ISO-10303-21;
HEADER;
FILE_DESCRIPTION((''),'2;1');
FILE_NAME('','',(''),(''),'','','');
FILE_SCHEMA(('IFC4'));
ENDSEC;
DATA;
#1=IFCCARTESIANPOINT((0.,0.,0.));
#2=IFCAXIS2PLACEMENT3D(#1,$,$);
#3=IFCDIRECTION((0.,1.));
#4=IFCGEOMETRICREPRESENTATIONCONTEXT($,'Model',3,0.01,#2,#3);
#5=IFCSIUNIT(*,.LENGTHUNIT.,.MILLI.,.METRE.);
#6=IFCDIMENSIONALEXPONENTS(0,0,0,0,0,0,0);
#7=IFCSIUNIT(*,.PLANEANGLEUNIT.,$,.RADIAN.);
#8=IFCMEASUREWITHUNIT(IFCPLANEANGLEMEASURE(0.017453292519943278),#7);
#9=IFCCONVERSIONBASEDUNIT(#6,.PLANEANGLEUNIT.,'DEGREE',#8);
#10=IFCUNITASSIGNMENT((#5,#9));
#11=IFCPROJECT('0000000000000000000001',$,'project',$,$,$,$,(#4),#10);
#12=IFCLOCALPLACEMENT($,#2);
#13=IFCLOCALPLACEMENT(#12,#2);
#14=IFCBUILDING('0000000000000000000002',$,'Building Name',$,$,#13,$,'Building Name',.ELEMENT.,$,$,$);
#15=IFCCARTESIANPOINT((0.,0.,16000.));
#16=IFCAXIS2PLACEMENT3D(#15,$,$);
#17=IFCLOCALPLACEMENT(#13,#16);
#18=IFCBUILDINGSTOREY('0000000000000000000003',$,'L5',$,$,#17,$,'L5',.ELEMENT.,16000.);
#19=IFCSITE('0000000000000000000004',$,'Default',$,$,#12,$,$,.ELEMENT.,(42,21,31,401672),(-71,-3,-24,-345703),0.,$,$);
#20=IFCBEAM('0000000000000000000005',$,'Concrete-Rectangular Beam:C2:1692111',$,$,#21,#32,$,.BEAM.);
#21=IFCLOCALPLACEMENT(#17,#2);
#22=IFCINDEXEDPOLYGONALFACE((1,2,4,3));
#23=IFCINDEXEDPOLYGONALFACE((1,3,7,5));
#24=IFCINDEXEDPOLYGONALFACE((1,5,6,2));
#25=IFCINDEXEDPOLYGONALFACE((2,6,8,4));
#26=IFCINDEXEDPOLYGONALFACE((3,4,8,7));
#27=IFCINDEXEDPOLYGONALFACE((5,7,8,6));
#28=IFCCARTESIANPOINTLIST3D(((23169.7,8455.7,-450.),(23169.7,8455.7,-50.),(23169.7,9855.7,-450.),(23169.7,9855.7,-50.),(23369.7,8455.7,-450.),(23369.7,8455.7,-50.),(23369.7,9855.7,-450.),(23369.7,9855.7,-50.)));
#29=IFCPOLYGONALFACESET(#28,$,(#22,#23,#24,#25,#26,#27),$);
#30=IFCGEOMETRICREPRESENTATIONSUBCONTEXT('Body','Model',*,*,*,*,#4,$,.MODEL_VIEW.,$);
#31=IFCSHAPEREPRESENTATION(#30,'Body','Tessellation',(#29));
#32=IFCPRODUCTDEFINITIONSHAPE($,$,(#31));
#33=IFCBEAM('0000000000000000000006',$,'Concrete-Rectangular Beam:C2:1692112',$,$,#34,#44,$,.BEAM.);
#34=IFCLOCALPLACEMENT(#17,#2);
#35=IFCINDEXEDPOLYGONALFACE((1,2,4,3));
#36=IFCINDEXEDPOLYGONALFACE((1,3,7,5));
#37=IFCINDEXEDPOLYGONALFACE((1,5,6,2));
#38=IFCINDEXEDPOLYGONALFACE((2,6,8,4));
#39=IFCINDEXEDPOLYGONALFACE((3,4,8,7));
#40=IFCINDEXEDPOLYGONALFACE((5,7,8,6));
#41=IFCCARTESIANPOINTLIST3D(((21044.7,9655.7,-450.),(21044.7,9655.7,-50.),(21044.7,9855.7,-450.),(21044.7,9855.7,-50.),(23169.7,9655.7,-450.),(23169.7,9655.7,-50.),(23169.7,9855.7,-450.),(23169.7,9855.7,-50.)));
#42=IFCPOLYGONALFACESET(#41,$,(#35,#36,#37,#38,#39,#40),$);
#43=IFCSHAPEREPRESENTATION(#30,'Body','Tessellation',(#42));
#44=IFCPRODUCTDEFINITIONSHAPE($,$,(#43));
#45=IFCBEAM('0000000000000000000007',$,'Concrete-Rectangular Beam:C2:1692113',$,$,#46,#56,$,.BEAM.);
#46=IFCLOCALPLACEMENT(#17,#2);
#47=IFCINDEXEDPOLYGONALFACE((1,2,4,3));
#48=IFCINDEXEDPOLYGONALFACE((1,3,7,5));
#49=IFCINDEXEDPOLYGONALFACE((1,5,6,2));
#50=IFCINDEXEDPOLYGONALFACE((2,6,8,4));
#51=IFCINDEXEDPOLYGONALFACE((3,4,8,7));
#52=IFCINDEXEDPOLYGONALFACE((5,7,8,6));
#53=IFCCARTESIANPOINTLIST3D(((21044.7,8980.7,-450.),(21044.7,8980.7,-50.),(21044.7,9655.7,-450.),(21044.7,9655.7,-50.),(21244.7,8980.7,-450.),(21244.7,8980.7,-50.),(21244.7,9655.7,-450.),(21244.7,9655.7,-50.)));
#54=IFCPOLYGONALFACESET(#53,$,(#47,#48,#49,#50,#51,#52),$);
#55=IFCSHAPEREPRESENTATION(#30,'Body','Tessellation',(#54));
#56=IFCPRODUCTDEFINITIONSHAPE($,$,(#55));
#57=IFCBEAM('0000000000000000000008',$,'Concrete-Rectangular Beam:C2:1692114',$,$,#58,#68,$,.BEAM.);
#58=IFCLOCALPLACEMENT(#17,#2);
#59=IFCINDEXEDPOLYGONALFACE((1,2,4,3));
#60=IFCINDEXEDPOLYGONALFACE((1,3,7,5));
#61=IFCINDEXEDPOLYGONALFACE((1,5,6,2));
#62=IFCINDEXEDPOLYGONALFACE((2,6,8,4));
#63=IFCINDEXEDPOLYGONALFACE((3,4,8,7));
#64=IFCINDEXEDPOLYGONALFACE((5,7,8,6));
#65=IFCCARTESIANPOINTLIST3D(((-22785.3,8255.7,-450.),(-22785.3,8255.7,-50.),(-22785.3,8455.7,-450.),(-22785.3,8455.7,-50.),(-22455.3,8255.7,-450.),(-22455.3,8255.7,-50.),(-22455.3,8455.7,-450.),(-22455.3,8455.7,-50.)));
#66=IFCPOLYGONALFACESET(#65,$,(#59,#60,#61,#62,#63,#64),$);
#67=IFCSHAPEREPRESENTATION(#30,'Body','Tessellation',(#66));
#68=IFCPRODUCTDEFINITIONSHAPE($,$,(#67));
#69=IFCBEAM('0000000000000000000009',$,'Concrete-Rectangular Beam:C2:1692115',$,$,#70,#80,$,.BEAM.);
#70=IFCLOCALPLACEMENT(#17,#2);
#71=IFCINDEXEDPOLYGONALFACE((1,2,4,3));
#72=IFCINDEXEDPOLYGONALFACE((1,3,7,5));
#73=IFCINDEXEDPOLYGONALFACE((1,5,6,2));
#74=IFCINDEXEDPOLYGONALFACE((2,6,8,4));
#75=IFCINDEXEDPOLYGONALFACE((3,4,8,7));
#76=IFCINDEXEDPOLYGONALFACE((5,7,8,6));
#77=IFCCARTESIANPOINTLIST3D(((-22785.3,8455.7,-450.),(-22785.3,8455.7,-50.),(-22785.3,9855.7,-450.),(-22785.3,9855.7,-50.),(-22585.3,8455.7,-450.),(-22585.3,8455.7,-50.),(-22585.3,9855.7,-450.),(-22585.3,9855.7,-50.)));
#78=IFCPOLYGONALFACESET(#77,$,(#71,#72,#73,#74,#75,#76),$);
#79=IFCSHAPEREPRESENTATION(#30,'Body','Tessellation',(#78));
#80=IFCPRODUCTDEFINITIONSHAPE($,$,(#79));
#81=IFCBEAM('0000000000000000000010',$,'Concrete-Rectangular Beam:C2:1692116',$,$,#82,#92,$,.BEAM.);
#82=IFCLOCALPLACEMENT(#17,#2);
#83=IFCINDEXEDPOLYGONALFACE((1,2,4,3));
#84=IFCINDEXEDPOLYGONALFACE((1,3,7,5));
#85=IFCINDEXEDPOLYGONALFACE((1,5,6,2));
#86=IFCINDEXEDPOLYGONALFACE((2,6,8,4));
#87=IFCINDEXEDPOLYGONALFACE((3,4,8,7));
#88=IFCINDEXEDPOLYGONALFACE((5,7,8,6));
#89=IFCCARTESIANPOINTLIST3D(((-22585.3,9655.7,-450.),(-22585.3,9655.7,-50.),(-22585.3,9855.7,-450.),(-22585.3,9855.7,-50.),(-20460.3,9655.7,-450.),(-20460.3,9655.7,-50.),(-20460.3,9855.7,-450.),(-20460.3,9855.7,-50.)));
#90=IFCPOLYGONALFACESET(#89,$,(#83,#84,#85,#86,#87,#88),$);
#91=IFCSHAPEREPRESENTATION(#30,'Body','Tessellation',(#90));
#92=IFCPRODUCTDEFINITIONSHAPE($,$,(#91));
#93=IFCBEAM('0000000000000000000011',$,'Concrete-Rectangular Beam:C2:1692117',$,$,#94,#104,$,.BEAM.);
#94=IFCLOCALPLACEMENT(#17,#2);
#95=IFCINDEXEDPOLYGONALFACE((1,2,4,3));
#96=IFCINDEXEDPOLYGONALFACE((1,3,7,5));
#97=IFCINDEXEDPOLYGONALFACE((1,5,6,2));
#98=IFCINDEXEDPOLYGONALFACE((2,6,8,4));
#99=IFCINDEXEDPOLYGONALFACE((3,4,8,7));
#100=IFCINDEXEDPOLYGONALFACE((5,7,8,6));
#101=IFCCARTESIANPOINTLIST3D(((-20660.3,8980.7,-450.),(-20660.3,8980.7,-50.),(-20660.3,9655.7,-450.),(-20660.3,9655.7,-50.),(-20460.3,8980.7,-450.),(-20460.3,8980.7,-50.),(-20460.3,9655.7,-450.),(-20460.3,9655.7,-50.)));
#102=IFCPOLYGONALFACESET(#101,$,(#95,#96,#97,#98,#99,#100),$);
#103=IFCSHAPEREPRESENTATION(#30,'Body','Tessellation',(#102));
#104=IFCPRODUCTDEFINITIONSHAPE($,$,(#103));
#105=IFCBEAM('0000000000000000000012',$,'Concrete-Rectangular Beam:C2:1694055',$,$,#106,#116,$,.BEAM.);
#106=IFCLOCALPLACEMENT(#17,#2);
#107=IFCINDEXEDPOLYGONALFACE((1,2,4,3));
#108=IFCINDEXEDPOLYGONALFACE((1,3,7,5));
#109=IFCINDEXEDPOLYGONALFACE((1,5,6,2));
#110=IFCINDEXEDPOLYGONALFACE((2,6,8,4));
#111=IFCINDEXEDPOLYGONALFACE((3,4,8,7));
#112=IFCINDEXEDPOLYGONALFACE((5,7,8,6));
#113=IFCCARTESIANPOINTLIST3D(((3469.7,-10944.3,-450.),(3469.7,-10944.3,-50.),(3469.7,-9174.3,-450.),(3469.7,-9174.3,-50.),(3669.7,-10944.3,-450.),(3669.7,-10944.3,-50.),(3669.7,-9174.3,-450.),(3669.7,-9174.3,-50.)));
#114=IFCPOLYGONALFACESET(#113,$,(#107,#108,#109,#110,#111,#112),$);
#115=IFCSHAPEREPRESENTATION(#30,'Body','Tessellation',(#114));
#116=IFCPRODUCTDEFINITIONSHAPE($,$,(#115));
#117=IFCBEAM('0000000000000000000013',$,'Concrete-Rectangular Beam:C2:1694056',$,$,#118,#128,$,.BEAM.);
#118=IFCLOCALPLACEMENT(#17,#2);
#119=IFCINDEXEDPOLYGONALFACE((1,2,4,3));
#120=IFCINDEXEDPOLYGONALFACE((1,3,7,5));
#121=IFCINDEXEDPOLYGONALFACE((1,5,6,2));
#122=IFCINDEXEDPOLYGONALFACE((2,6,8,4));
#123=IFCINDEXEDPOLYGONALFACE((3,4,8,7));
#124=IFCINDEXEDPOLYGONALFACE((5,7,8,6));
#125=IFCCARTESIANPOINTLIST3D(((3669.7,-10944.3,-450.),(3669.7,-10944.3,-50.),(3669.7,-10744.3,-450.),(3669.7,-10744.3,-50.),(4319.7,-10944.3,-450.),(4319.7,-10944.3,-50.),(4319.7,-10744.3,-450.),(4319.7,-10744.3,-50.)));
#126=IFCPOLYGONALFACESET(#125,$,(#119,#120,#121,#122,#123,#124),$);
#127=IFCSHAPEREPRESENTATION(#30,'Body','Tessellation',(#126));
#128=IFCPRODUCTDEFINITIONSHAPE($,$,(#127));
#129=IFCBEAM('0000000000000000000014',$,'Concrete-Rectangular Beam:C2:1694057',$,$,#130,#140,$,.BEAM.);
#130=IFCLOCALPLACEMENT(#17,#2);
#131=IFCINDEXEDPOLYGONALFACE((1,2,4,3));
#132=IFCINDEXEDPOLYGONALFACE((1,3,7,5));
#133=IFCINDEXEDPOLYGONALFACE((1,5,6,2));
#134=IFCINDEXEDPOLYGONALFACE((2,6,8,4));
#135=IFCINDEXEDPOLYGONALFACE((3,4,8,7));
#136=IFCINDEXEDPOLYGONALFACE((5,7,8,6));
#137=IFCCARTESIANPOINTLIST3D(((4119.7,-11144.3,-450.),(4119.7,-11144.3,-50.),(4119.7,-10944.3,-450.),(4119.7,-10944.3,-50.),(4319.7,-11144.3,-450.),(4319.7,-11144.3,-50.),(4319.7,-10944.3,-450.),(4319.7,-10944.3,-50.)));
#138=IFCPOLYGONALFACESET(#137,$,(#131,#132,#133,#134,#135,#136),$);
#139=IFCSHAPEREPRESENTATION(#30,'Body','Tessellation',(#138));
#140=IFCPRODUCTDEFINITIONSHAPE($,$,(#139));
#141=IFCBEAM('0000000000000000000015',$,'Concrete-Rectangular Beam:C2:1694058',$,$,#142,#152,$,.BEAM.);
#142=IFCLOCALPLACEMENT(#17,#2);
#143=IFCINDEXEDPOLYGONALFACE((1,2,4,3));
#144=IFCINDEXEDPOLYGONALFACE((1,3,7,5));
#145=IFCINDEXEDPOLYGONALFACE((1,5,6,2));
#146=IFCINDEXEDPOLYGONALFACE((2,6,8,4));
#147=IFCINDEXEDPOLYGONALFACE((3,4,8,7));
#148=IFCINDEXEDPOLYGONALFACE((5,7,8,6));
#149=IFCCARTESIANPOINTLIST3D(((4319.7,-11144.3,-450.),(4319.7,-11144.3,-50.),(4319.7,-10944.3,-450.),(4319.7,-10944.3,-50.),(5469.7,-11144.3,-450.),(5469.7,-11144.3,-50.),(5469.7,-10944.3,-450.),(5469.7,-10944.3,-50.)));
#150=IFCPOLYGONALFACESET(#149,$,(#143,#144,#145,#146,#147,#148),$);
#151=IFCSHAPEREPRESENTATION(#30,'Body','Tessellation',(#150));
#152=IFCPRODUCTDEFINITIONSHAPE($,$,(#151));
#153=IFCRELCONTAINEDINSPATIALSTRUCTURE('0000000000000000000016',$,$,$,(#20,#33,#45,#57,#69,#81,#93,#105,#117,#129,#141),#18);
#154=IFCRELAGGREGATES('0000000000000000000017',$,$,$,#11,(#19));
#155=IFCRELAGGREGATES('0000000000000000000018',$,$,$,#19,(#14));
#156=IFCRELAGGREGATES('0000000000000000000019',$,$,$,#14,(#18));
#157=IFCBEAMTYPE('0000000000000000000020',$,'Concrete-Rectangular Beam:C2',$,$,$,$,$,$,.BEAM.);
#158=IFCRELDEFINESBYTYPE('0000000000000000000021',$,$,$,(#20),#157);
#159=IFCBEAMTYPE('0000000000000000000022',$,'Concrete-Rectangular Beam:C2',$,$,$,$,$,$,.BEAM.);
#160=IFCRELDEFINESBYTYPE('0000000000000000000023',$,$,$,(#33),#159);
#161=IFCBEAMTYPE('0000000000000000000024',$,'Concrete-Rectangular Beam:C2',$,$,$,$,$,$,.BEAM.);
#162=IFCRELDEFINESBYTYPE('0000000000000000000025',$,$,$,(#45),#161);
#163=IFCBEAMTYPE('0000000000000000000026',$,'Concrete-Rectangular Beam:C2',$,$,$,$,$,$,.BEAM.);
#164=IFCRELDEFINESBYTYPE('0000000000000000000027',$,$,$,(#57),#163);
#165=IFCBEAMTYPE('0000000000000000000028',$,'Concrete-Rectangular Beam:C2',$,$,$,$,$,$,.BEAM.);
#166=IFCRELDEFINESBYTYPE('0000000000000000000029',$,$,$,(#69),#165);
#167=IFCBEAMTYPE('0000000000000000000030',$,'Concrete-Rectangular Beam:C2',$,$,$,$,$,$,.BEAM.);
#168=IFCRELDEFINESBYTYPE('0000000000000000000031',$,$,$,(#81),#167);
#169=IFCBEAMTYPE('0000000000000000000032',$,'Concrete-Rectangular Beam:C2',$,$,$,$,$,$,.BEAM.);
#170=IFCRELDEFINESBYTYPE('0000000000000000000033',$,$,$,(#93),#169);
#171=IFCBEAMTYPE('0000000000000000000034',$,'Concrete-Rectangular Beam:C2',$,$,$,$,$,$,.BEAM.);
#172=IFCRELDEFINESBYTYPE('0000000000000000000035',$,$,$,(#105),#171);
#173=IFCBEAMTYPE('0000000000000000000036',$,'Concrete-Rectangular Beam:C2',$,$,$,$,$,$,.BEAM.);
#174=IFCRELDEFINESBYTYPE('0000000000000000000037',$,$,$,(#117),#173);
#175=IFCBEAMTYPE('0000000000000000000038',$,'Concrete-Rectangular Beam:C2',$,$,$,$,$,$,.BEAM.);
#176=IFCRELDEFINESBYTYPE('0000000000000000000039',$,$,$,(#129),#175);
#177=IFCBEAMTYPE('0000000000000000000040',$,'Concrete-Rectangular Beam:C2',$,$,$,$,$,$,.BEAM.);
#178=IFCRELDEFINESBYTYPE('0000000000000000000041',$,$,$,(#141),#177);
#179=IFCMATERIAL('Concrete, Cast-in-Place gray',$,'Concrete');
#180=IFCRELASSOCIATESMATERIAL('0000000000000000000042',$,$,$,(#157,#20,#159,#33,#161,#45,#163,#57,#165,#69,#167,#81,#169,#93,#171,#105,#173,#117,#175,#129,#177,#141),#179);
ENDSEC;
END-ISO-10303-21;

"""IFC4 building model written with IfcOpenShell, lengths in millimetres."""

from ifc_helpers import new_model, entity, si_unit, converted_unit, direction, frame, origin, place, context, subcontext, project, spatial, indexed_curve, outline, extrude, source, transform, mapped, material, type_object, type_shapes, element, save


model = new_model("IFC4")

# Units and contexts
model_context = context("Model", 3, precision=0.01, world=origin(), true_north=direction((0.0, 1.0)))
body_context = subcontext(model_context, "Body", "Model", "MODEL_VIEW")
ifc_project = project(units=[si_unit("LENGTHUNIT", "METRE", prefix="MILLI"), converted_unit("PLANEANGLEUNIT", "DEGREE", entity("IfcPlaneAngleMeasure", 0.017453292519943278), si_unit("PLANEANGLEUNIT", "RADIAN"), dimensions=[0, 0, 0, 0, 0, 0, 0])], contexts=[model_context])

# Site, building, storey
site_placement = place(None, origin())
site = spatial("IfcSite", under=ifc_project, at=site_placement, Name="Default", CompositionType="ELEMENT", RefLatitude=(42, 21, 31, 401672), RefLongitude=(-71, -3, -24, -345703), RefElevation=0.0)
building_placement = place(site_placement, origin())
building = spatial("IfcBuilding", under=site, at=building_placement, Name="Building Name", LongName="Building Name", CompositionType="ELEMENT")
storey_placement = place(building_placement, frame((0.0, 0.0, 16000.0)))
storey = spatial("IfcBuildingStorey", under=building, at=storey_placement, Name="L5", LongName="L5", CompositionType="ELEMENT", Elevation=16000.0)

# Beams
ifc_material = material(Name="Concrete, Cast-in-Place gray", Category="Concrete")
beam_type_1 = type_object("IfcBeamType", Name="Concrete-Rectangular Beam:C2", PredefinedType="BEAM", material=ifc_material)
shared_shape_1 = source(origin(), body_context, "Body", "SweptSolid", [
    extrude(outline(indexed_curve([(-100.0, -200.0), (100.0, -200.0), (100.0, 200.0), (-100.0, 200.0), (-100.0, -200.0)], self_intersect=False)), frame((23269.7, 8455.7, 15750.0), z_axis=(0.0, 1.0, 0.0), x_axis=(-1.0, 0.0, 0.0)), (0.0, 0.0, 1.0), 1400.0),
])
type_shapes(beam_type_1, [shared_shape_1])
beam_1_placement = place(storey_placement, frame((0.0, 0.0, -16000.0)))
element("IfcBeam", 1, at=beam_1_placement, inside=storey, type_object=beam_type_1, material=ifc_material, Name="Concrete-Rectangular Beam:C2:1692111", PredefinedType="BEAM", context=body_context, shape_type="MappedRepresentation", body=[
    mapped(shared_shape_1, transform((0.0, 0.0, 0.0), scale=1.0)),
])
beam_type_2 = type_object("IfcBeamType", Name="Concrete-Rectangular Beam:C2", PredefinedType="BEAM", material=ifc_material)
shared_shape_2 = source(origin(), body_context, "Body", "SweptSolid", [
    extrude(outline(indexed_curve([(-200.0, -100.0), (200.0, -100.0), (200.0, 100.0), (-200.0, 100.0), (-200.0, -100.0)], self_intersect=False)), frame((23169.7, 9755.7, 15750.0), z_axis=(-1.0, 0.0, 0.0), x_axis=(0.0, 0.0, -1.0)), (0.0, 0.0, 1.0), 2125.0),
])
type_shapes(beam_type_2, [shared_shape_2])
beam_2_placement = place(storey_placement, frame((0.0, 0.0, -16000.0)))
element("IfcBeam", 2, at=beam_2_placement, inside=storey, type_object=beam_type_2, material=ifc_material, Name="Concrete-Rectangular Beam:C2:1692112", PredefinedType="BEAM", context=body_context, shape_type="MappedRepresentation", body=[
    mapped(shared_shape_2, transform((0.0, 0.0, 0.0), scale=1.0)),
])
beam_type_3 = type_object("IfcBeamType", Name="Concrete-Rectangular Beam:C2", PredefinedType="BEAM", material=ifc_material)
shared_shape_3 = source(origin(), body_context, "Body", "SweptSolid", [
    extrude(outline(indexed_curve([(-100.0, -200.0), (100.0, -200.0), (100.0, 200.0), (-100.0, 200.0), (-100.0, -200.0)], self_intersect=False)), frame((21144.7, 9655.7, 15750.0), z_axis=(0.0, -1.0, 0.0), x_axis=(-1.0, 0.0, 0.0)), (0.0, 0.0, 1.0), 675.0),
])
type_shapes(beam_type_3, [shared_shape_3])
beam_3_placement = place(storey_placement, frame((0.0, 0.0, -16000.0)))
element("IfcBeam", 3, at=beam_3_placement, inside=storey, type_object=beam_type_3, material=ifc_material, Name="Concrete-Rectangular Beam:C2:1692113", PredefinedType="BEAM", context=body_context, shape_type="MappedRepresentation", body=[
    mapped(shared_shape_3, transform((0.0, 0.0, 0.0), scale=1.0)),
])
beam_type_4 = type_object("IfcBeamType", Name="Concrete-Rectangular Beam:C2", PredefinedType="BEAM", material=ifc_material)
shared_shape_4 = source(origin(), body_context, "Body", "SweptSolid", [
    extrude(outline(indexed_curve([(-200.0, -100.0), (200.0, -100.0), (200.0, 100.0), (-200.0, 100.0), (-200.0, -100.0)], self_intersect=False)), frame((-22455.3, 8355.7, 15750.0), z_axis=(-1.0, 0.0, 0.0), x_axis=(0.0, 0.0, -1.0)), (0.0, 0.0, 1.0), 330.0),
])
type_shapes(beam_type_4, [shared_shape_4])
beam_4_placement = place(storey_placement, frame((0.0, 0.0, -16000.0)))
element("IfcBeam", 4, at=beam_4_placement, inside=storey, type_object=beam_type_4, material=ifc_material, Name="Concrete-Rectangular Beam:C2:1692114", PredefinedType="BEAM", context=body_context, shape_type="MappedRepresentation", body=[
    mapped(shared_shape_4, transform((0.0, 0.0, 0.0), scale=1.0)),
])
beam_type_5 = type_object("IfcBeamType", Name="Concrete-Rectangular Beam:C2", PredefinedType="BEAM", material=ifc_material)
shared_shape_5 = source(origin(), body_context, "Body", "SweptSolid", [
    extrude(outline(indexed_curve([(-100.0, -200.0), (100.0, -200.0), (100.0, 200.0), (-100.0, 200.0), (-100.0, -200.0)], self_intersect=False)), frame((-22685.3, 8455.7, 15750.0), z_axis=(0.0, 1.0, 0.0), x_axis=(-1.0, 0.0, 0.0)), (0.0, 0.0, 1.0), 1400.0),
])
type_shapes(beam_type_5, [shared_shape_5])
beam_5_placement = place(storey_placement, frame((0.0, 0.0, -16000.0)))
element("IfcBeam", 5, at=beam_5_placement, inside=storey, type_object=beam_type_5, material=ifc_material, Name="Concrete-Rectangular Beam:C2:1692115", PredefinedType="BEAM", context=body_context, shape_type="MappedRepresentation", body=[
    mapped(shared_shape_5, transform((0.0, 0.0, 0.0), scale=1.0)),
])
beam_type_6 = type_object("IfcBeamType", Name="Concrete-Rectangular Beam:C2", PredefinedType="BEAM", material=ifc_material)
shared_shape_6 = source(origin(), body_context, "Body", "SweptSolid", [
    extrude(outline(indexed_curve([(-200.0, -100.0), (200.0, -100.0), (200.0, 100.0), (-200.0, 100.0), (-200.0, -100.0)], self_intersect=False)), frame((-22585.3, 9755.7, 15750.0), z_axis=(1.0, 0.0, 0.0), x_axis=(0.0, 0.0, -1.0)), (0.0, 0.0, 1.0), 2125.0),
])
type_shapes(beam_type_6, [shared_shape_6])
beam_6_placement = place(storey_placement, frame((0.0, 0.0, -16000.0)))
element("IfcBeam", 6, at=beam_6_placement, inside=storey, type_object=beam_type_6, material=ifc_material, Name="Concrete-Rectangular Beam:C2:1692116", PredefinedType="BEAM", context=body_context, shape_type="MappedRepresentation", body=[
    mapped(shared_shape_6, transform((0.0, 0.0, 0.0), scale=1.0)),
])
beam_type_7 = type_object("IfcBeamType", Name="Concrete-Rectangular Beam:C2", PredefinedType="BEAM", material=ifc_material)
shared_shape_7 = source(origin(), body_context, "Body", "SweptSolid", [
    extrude(outline(indexed_curve([(-100.0, -200.0), (100.0, -200.0), (100.0, 200.0), (-100.0, 200.0), (-100.0, -200.0)], self_intersect=False)), frame((-20560.3, 9655.7, 15750.0), z_axis=(0.0, -1.0, 0.0), x_axis=(-1.0, 0.0, 0.0)), (0.0, 0.0, 1.0), 675.0),
])
type_shapes(beam_type_7, [shared_shape_7])
beam_7_placement = place(storey_placement, frame((0.0, 0.0, -16000.0)))
element("IfcBeam", 7, at=beam_7_placement, inside=storey, type_object=beam_type_7, material=ifc_material, Name="Concrete-Rectangular Beam:C2:1692117", PredefinedType="BEAM", context=body_context, shape_type="MappedRepresentation", body=[
    mapped(shared_shape_7, transform((0.0, 0.0, 0.0), scale=1.0)),
])
beam_type_8 = type_object("IfcBeamType", Name="Concrete-Rectangular Beam:C2", PredefinedType="BEAM", material=ifc_material)
shared_shape_8 = source(origin(), body_context, "Body", "SweptSolid", [
    extrude(outline(indexed_curve([(-100.0, -200.0), (100.0, -200.0), (100.0, 200.0), (-100.0, 200.0), (-100.0, -200.0)], self_intersect=False)), frame((3569.7, -9174.3, 15750.0), z_axis=(0.0, -1.0, 0.0), x_axis=(-1.0, 0.0, 0.0)), (0.0, 0.0, 1.0), 1770.0),
])
type_shapes(beam_type_8, [shared_shape_8])
beam_8_placement = place(storey_placement, frame((0.0, 0.0, -16000.0)))
element("IfcBeam", 8, at=beam_8_placement, inside=storey, type_object=beam_type_8, material=ifc_material, Name="Concrete-Rectangular Beam:C2:1694055", PredefinedType="BEAM", context=body_context, shape_type="MappedRepresentation", body=[
    mapped(shared_shape_8, transform((0.0, 0.0, 0.0), scale=1.0)),
])
beam_type_9 = type_object("IfcBeamType", Name="Concrete-Rectangular Beam:C2", PredefinedType="BEAM", material=ifc_material)
shared_shape_9 = source(origin(), body_context, "Body", "SweptSolid", [
    extrude(outline(indexed_curve([(-200.0, -100.0), (200.0, -100.0), (200.0, 100.0), (-200.0, 100.0), (-200.0, -100.0)], self_intersect=False)), frame((3669.7, -10844.3, 15750.0), z_axis=(1.0, 0.0, 0.0), x_axis=(0.0, 0.0, -1.0)), (0.0, 0.0, 1.0), 650.0),
])
type_shapes(beam_type_9, [shared_shape_9])
beam_9_placement = place(storey_placement, frame((0.0, 0.0, -16000.0)))
element("IfcBeam", 9, at=beam_9_placement, inside=storey, type_object=beam_type_9, material=ifc_material, Name="Concrete-Rectangular Beam:C2:1694056", PredefinedType="BEAM", context=body_context, shape_type="MappedRepresentation", body=[
    mapped(shared_shape_9, transform((0.0, 0.0, 0.0), scale=1.0)),
])
beam_type_10 = type_object("IfcBeamType", Name="Concrete-Rectangular Beam:C2", PredefinedType="BEAM", material=ifc_material)
shared_shape_10 = source(origin(), body_context, "Body", "SweptSolid", [
    extrude(outline(indexed_curve([(-100.0, -200.0), (100.0, -200.0), (100.0, 200.0), (-100.0, 200.0), (-100.0, -200.0)], self_intersect=False)), frame((4219.7, -10944.3, 15750.0), z_axis=(0.0, -1.0, 0.0), x_axis=(-1.0, 0.0, 0.0)), (0.0, 0.0, 1.0), 200.0),
])
type_shapes(beam_type_10, [shared_shape_10])
beam_10_placement = place(storey_placement, frame((0.0, 0.0, -16000.0)))
element("IfcBeam", 10, at=beam_10_placement, inside=storey, type_object=beam_type_10, material=ifc_material, Name="Concrete-Rectangular Beam:C2:1694057", PredefinedType="BEAM", context=body_context, shape_type="MappedRepresentation", body=[
    mapped(shared_shape_10, transform((0.0, 0.0, 0.0), scale=1.0)),
])
beam_type_11 = type_object("IfcBeamType", Name="Concrete-Rectangular Beam:C2", PredefinedType="BEAM", material=ifc_material)
shared_shape_11 = source(origin(), body_context, "Body", "SweptSolid", [
    extrude(outline(indexed_curve([(-200.0, -100.0), (200.0, -100.0), (200.0, 100.0), (-200.0, 100.0), (-200.0, -100.0)], self_intersect=False)), frame((4319.7, -11044.3, 15750.0), z_axis=(1.0, 0.0, 0.0), x_axis=(0.0, 0.0, -1.0)), (0.0, 0.0, 1.0), 1150.0),
])
type_shapes(beam_type_11, [shared_shape_11])
beam_11_placement = place(storey_placement, frame((0.0, 0.0, -16000.0)))
element("IfcBeam", 11, at=beam_11_placement, inside=storey, type_object=beam_type_11, material=ifc_material, Name="Concrete-Rectangular Beam:C2:1694058", PredefinedType="BEAM", context=body_context, shape_type="MappedRepresentation", body=[
    mapped(shared_shape_11, transform((0.0, 0.0, 0.0), scale=1.0)),
])

save(model, "model.ifc")
